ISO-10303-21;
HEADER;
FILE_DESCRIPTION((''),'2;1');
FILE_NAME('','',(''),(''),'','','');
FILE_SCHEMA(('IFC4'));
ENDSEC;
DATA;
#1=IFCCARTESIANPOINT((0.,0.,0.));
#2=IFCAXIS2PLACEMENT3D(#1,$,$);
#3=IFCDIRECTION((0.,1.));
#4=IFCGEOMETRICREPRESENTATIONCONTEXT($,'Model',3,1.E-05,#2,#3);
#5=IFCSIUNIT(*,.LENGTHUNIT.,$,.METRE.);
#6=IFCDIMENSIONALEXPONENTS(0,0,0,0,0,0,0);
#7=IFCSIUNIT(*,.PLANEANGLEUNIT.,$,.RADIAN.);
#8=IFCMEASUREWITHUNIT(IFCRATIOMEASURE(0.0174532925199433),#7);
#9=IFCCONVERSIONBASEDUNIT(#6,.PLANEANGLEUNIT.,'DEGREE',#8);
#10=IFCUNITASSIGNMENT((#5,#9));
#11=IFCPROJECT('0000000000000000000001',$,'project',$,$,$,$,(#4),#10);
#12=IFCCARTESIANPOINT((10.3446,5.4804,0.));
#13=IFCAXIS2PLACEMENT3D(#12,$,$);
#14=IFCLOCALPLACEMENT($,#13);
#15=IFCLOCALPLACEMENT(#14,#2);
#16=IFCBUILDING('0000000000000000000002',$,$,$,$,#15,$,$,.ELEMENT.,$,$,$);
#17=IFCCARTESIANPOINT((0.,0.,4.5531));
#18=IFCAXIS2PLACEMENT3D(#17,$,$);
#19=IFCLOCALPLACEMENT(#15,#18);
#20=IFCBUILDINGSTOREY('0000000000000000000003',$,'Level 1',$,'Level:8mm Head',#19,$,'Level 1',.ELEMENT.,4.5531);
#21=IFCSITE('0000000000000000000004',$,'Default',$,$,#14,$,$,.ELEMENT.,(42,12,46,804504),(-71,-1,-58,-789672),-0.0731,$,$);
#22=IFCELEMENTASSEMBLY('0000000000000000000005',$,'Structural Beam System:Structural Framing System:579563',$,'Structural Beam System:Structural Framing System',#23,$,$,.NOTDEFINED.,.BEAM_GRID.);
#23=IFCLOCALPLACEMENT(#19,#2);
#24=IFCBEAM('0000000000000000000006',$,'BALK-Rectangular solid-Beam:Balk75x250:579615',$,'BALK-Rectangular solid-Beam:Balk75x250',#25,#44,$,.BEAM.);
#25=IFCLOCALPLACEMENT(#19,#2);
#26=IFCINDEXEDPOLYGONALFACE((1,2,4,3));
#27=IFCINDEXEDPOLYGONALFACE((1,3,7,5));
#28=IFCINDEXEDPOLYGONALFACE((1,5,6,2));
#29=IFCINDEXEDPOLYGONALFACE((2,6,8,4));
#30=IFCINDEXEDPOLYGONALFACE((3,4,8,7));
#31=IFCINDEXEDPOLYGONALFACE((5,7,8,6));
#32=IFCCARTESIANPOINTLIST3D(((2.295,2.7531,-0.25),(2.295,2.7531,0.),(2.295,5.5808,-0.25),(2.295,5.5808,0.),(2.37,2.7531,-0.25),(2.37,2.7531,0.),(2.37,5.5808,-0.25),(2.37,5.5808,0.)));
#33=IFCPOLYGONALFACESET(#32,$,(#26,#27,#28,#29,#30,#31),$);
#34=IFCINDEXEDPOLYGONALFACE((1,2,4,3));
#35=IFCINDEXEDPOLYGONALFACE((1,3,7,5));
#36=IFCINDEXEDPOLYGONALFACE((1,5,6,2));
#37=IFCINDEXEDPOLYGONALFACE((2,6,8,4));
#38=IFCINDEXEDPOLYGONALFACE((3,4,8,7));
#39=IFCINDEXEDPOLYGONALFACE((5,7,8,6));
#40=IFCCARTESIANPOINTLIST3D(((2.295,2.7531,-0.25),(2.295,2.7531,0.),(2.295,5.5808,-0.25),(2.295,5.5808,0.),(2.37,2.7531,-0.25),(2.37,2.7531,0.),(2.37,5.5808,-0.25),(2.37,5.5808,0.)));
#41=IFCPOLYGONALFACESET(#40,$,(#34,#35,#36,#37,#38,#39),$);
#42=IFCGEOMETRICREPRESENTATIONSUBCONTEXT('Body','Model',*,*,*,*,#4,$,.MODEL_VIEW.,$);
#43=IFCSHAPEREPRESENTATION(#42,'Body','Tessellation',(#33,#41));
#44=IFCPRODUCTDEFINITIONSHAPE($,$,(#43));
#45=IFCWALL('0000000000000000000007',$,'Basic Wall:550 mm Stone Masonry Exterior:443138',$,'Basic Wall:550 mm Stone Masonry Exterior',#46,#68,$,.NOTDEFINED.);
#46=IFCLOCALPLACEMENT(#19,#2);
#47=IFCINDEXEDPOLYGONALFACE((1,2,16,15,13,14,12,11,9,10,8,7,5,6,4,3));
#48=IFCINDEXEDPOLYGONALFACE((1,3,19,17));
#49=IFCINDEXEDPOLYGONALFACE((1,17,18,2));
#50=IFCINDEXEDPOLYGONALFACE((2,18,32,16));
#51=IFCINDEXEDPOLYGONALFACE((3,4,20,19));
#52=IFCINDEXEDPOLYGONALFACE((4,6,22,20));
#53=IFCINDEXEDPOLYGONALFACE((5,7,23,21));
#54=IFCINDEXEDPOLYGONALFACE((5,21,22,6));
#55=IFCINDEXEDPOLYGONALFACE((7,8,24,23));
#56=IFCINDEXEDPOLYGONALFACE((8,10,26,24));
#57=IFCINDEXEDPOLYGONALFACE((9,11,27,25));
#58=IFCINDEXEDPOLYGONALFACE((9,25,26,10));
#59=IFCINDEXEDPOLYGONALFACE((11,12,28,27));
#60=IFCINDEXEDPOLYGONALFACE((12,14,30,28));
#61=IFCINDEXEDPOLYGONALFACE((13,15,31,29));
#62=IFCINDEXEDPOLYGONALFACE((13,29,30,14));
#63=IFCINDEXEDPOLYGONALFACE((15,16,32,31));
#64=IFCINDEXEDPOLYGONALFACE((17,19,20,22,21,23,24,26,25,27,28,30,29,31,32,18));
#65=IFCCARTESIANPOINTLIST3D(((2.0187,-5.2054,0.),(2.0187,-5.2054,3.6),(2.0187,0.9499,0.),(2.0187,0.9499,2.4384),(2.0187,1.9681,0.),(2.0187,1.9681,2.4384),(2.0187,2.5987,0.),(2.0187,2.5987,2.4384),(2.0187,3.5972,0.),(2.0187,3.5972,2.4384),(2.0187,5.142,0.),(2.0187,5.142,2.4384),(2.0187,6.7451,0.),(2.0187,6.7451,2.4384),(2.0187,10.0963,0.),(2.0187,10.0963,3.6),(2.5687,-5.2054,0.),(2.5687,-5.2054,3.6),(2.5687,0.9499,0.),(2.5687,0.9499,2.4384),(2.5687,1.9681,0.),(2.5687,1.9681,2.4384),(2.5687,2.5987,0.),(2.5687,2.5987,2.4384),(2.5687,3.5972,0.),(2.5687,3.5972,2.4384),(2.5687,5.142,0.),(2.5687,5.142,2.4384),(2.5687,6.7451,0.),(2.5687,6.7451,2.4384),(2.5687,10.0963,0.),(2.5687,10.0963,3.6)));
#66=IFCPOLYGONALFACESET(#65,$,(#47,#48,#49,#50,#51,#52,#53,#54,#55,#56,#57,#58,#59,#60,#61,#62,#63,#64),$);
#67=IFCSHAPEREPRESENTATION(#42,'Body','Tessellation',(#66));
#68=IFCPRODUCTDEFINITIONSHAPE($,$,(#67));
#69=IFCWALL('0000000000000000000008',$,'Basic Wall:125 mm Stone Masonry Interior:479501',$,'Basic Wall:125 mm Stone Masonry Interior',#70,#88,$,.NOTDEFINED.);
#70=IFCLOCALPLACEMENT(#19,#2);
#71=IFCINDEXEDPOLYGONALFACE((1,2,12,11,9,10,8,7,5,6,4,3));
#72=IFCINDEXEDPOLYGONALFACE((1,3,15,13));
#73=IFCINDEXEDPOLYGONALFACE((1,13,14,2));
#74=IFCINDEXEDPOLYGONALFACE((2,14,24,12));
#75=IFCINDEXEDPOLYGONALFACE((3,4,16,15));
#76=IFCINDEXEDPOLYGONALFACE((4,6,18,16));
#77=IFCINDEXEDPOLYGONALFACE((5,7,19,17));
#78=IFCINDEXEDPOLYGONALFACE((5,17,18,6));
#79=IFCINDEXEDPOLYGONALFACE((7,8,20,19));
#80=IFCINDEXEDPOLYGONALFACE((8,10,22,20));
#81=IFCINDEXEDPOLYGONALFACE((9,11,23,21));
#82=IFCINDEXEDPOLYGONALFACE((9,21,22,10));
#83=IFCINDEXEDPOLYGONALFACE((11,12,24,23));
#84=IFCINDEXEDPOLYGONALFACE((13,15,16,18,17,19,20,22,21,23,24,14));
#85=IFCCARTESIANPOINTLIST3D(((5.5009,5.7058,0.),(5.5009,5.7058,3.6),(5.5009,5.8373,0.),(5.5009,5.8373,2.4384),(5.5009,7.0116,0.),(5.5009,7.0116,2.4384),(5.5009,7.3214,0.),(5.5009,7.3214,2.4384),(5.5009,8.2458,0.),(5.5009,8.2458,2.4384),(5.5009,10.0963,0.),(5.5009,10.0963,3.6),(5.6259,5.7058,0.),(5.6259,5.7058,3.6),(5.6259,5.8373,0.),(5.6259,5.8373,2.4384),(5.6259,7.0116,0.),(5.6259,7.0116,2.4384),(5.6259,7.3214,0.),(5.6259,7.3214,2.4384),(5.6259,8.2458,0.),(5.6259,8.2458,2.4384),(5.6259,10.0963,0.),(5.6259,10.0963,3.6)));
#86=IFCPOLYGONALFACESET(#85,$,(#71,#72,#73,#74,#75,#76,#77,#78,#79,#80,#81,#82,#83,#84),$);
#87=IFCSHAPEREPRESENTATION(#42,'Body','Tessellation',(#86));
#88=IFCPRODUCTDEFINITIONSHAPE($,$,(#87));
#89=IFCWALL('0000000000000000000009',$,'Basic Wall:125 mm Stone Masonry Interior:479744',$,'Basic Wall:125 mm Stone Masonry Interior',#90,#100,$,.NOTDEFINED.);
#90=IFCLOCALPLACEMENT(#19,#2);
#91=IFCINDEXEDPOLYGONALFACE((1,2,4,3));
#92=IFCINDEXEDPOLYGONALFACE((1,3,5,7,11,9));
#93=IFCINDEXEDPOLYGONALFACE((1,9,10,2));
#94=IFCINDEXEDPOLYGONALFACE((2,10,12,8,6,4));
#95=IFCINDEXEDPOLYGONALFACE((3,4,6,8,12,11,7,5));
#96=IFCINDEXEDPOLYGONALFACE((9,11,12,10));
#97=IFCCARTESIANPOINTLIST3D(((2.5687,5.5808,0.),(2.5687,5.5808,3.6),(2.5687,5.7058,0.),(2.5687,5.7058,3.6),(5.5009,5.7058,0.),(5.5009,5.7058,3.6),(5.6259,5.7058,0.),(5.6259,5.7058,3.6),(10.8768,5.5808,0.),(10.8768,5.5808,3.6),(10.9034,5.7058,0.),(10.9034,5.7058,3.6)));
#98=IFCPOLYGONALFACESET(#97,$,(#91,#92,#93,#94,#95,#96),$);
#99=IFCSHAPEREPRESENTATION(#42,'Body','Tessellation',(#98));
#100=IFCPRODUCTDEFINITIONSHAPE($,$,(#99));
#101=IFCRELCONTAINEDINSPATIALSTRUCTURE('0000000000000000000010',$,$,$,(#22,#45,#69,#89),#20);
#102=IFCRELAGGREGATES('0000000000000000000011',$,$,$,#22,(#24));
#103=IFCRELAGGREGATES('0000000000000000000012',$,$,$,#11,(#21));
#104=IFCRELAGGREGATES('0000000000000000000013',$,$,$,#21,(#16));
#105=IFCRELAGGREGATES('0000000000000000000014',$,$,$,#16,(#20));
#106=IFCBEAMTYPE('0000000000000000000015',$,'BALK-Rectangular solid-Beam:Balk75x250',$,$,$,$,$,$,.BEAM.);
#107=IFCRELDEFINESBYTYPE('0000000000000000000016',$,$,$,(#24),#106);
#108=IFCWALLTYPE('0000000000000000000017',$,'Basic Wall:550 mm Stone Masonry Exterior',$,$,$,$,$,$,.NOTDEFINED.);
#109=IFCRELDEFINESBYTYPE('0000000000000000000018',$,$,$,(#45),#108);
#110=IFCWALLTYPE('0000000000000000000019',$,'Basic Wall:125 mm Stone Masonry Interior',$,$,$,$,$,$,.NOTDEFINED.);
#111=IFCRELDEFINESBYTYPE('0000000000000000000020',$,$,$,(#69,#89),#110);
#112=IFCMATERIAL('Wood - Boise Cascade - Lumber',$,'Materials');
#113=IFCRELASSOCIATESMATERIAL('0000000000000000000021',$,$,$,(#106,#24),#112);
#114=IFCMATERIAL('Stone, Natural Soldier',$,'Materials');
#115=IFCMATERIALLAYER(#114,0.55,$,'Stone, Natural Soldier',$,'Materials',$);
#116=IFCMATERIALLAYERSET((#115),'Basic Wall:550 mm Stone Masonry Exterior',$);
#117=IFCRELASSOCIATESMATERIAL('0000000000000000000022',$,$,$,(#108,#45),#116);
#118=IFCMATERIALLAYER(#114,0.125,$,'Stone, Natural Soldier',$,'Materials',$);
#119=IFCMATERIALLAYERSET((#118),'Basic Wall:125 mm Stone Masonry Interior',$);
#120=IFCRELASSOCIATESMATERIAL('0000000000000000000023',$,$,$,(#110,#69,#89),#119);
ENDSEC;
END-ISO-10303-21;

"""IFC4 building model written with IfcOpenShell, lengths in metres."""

from ifc_helpers import new_model, entity, si_unit, converted_unit, direction, frame, frame_2d, origin, origin_2d_with_axis, place, context, subcontext, project, spatial, polyline, rectangle, outline, extrude, source, transform, mapped, material, layer, layer_set, layer_usage, material_profile, profile_set, profile_usage, type_object, type_shapes, element, aggregate, save


model = new_model("IFC4")

# Units and contexts
model_context = context("Model", 3, precision=1e-05, world=origin(), true_north=direction((0.0, 1.0)))
body_context = subcontext(model_context, "Body", "Model", "MODEL_VIEW")
ifc_project = project(units=[si_unit("LENGTHUNIT", "METRE"), converted_unit("PLANEANGLEUNIT", "DEGREE", entity("IfcRatioMeasure", 0.0174532925199433), si_unit("PLANEANGLEUNIT", "RADIAN"), dimensions=[0, 0, 0, 0, 0, 0, 0])], contexts=[model_context])

# Site, building, storey
site_placement = place(None, frame((10.3446, 5.4804, 0.0)))
site = spatial("IfcSite", under=ifc_project, at=site_placement, Name="Default", CompositionType="ELEMENT", RefLatitude=(42, 12, 46, 804504), RefLongitude=(-71, -1, -58, -789672), RefElevation=-0.0731)
building_placement = place(site_placement, origin())
building = spatial("IfcBuilding", under=site, at=building_placement, CompositionType="ELEMENT")
storey_placement = place(building_placement, frame((0.0, 0.0, 4.5531)))
storey = spatial("IfcBuildingStorey", under=building, at=storey_placement, Name="Level 1", ObjectType="Level:8mm Head", LongName="Level 1", CompositionType="ELEMENT", Elevation=4.5531)

# Shared definitions
ifc_material_1 = material(Name="Wood - Boise Cascade - Lumber", Category="Materials")
ifc_material_profile = material_profile(ifc_material_1, rectangle(XDim=0.25, YDim=0.075, at=frame_2d((0.0, 0.0), x_axis=(1.0, 0.0))), Name="Balk75x250")
ifc_profile_set = profile_set([ifc_material_profile], Name="Balk75x250")

# Element assembly, beam
assembly_1_placement = place(storey_placement, origin())
assembly_1 = element("IfcElementAssembly", 1, at=assembly_1_placement, inside=storey, Name="Structural Beam System:Structural Framing System:579563", ObjectType="Structural Beam System:Structural Framing System", AssemblyPlace="NOTDEFINED", PredefinedType="BEAM_GRID")
beam_type_1 = type_object("IfcBeamType", Name="BALK-Rectangular solid-Beam:Balk75x250", PredefinedType="BEAM", material=ifc_profile_set)
shared_shape_1 = source(origin(), body_context, "Body", "SweptSolid", [
    extrude(rectangle(XDim=0.25, YDim=0.075, at=origin_2d_with_axis()), frame((-1.4138, 0.0, 0.0), z_axis=(1.0, 0.0, 0.0), x_axis=(0.0, 0.0, -1.0)), (0.0, 0.0, 1.0), 2.8276),
    extrude(rectangle(XDim=0.25, YDim=0.075, at=origin_2d_with_axis()), frame((-1.4138, 0.0, 0.0), z_axis=(1.0, 0.0, 0.0), x_axis=(0.0, 0.0, -1.0)), (0.0, 0.0, 1.0), 2.8276),
])
type_shapes(beam_type_1, [shared_shape_1])
ifc_profile_usage_1 = profile_usage(ifc_profile_set, cardinal=8)
beam_1_placement = place(assembly_1_placement, frame((2.3325, 4.167, -0.125), z_axis=(0.0, 0.0, 1.0), x_axis=(0.0, -1.0, 0.0)))
beam_1 = element("IfcBeam", 2, at=beam_1_placement, type_object=beam_type_1, material=ifc_profile_usage_1, Name="BALK-Rectangular solid-Beam:Balk75x250:579615", ObjectType="BALK-Rectangular solid-Beam:Balk75x250", PredefinedType="BEAM", context=body_context, shape_type="MappedRepresentation", body=[
    mapped(shared_shape_1, transform((0.0, 0.0, 0.0), scale=1.0)),
])
aggregate(assembly_1, [beam_1])

# Walls, openings
ifc_material_2 = material(Name="Stone, Natural Soldier", Category="Materials")
ifc_layer_1 = layer(ifc_material_2, 0.55, Name="Stone, Natural Soldier", Category="Materials")
ifc_layer_set_1 = layer_set([ifc_layer_1], Name="Basic Wall:550 mm Stone Masonry Exterior")
ifc_layer_usage_1 = layer_usage(ifc_layer_set_1, "AXIS2", "NEGATIVE", 0.275)
wall_type_1 = type_object("IfcWallType", Name="Basic Wall:550 mm Stone Masonry Exterior", PredefinedType="NOTDEFINED", material=ifc_layer_set_1)
wall_1_placement = place(storey_placement, frame((2.2937, 10.0963, 0.0), z_axis=(0.0, 0.0, 1.0), x_axis=(0.0, -1.0, 0.0)))
wall_1 = element("IfcWall", 3, at=wall_1_placement, inside=storey, type_object=wall_type_1, material=ifc_layer_usage_1, Name="Basic Wall:550 mm Stone Masonry Exterior:443138", ObjectType="Basic Wall:550 mm Stone Masonry Exterior", PredefinedType="NOTDEFINED", context=body_context, shape_type="SweptSolid", body=[
    extrude(rectangle(XDim=15.3017, YDim=0.55, at=frame_2d((7.6509, 0.0), x_axis=(-1.0, 0.0))), origin(), (0.0, 0.0, 1.0), 3.6),
])
opening_1_placement = place(wall_1_placement, frame((7.4976, -0.275, 0.0)))
element("IfcOpeningElement", 4, at=opening_1_placement, cuts=wall_1, ObjectType="Opening", PredefinedType="OPENING", context=body_context, shape_type="SweptSolid", body=[
    extrude(rectangle(XDim=2.4384, YDim=0.9984, at=origin_2d_with_axis()), frame((-0.4992, 0.0, 1.2192), z_axis=(0.0, 1.0, 0.0), x_axis=(0.0, 0.0, -1.0)), (0.0, 0.0, 1.0), 0.55),
])
opening_2_placement = place(wall_1_placement, frame((9.1464, -0.275, 0.0)))
element("IfcOpeningElement", 5, at=opening_2_placement, cuts=wall_1, ObjectType="Opening", PredefinedType="OPENING", context=body_context, shape_type="SweptSolid", body=[
    extrude(rectangle(XDim=2.4384, YDim=1.0182, at=origin_2d_with_axis()), frame((-0.5091, 0.0, 1.2192), z_axis=(0.0, 1.0, 0.0), x_axis=(0.0, 0.0, -1.0)), (0.0, 0.0, 1.0), 0.55),
])
opening_3_placement = place(wall_1_placement, frame((4.9543, -0.275, 0.0)))
element("IfcOpeningElement", 6, at=opening_3_placement, cuts=wall_1, ObjectType="Opening", PredefinedType="OPENING", context=body_context, shape_type="SweptSolid", body=[
    extrude(rectangle(XDim=2.4384, YDim=1.6031, at=origin_2d_with_axis()), frame((-0.8015, 0.0, 1.2192), z_axis=(0.0, 1.0, 0.0), x_axis=(0.0, 0.0, -1.0)), (0.0, 0.0, 1.0), 0.55),
])
ifc_layer_2 = layer(ifc_material_2, 0.125, Name="Stone, Natural Soldier", Category="Materials")
ifc_layer_set_2 = layer_set([ifc_layer_2], Name="Basic Wall:125 mm Stone Masonry Interior")
ifc_layer_usage_2 = layer_usage(ifc_layer_set_2, "AXIS2", "NEGATIVE", 0.0625)
wall_type_2 = type_object("IfcWallType", Name="Basic Wall:125 mm Stone Masonry Interior", PredefinedType="NOTDEFINED", material=ifc_layer_set_2)
wall_2_placement = place(storey_placement, frame((5.5634, 10.0963, 0.0), z_axis=(0.0, 0.0, 1.0), x_axis=(0.0, -1.0, 0.0)))
wall_2 = element("IfcWall", 7, at=wall_2_placement, inside=storey, type_object=wall_type_2, material=ifc_layer_usage_2, Name="Basic Wall:125 mm Stone Masonry Interior:479501", ObjectType="Basic Wall:125 mm Stone Masonry Interior", PredefinedType="NOTDEFINED", context=body_context, shape_type="SweptSolid", body=[
    extrude(rectangle(XDim=4.3905, YDim=0.125, at=frame_2d((2.1953, 0.0), x_axis=(-1.0, 0.0))), origin(), (0.0, 0.0, 1.0), 3.6),
])
opening_4_placement = place(wall_2_placement, frame((2.7749, -0.0625, 0.0)))
element("IfcOpeningElement", 8, at=opening_4_placement, cuts=wall_2, ObjectType="Opening", PredefinedType="OPENING", context=body_context, shape_type="SweptSolid", body=[
    extrude(rectangle(XDim=2.4384, YDim=0.9245, at=frame_2d((0.0, 0.0), x_axis=(1.0, 0.0))), frame((-0.4622, 0.0, 1.2192), z_axis=(0.0, 1.0, 0.0), x_axis=(0.0, 0.0, -1.0)), (0.0, 0.0, 1.0), 0.125),
])
opening_5_placement = place(wall_2_placement, frame((4.259, -0.0625, 0.0)))
element("IfcOpeningElement", 9, at=opening_5_placement, cuts=wall_2, ObjectType="Opening", PredefinedType="OPENING", context=body_context, shape_type="SweptSolid", body=[
    extrude(rectangle(XDim=2.4384, YDim=1.1744, at=origin_2d_with_axis()), frame((-0.5872, 0.0, 1.2192), z_axis=(0.0, 1.0, 0.0), x_axis=(0.0, 0.0, -1.0)), (0.0, 0.0, 1.0), 0.125),
])

# Wall
ifc_layer_usage_3 = layer_usage(ifc_layer_set_2, "AXIS2", "NEGATIVE", 0.0625)
wall_3_placement = place(storey_placement, frame((2.5687, 5.6433, 0.0)))
element("IfcWall", 10, at=wall_3_placement, inside=storey, type_object=wall_type_2, material=ifc_layer_usage_3, Name="Basic Wall:125 mm Stone Masonry Interior:479744", ObjectType="Basic Wall:125 mm Stone Masonry Interior", PredefinedType="NOTDEFINED", context=body_context, shape_type="SweptSolid", body=[
    extrude(outline(polyline([(8.3082, -0.0625), (8.3347, 0.0625), (3.0572, 0.0625), (2.9322, 0.0625), (0.0, 0.0625), (0.0, -0.0625), (8.3082, -0.0625)])), origin(), (0.0, 0.0, 1.0), 3.6),
])

save(model, "model.ifc")
